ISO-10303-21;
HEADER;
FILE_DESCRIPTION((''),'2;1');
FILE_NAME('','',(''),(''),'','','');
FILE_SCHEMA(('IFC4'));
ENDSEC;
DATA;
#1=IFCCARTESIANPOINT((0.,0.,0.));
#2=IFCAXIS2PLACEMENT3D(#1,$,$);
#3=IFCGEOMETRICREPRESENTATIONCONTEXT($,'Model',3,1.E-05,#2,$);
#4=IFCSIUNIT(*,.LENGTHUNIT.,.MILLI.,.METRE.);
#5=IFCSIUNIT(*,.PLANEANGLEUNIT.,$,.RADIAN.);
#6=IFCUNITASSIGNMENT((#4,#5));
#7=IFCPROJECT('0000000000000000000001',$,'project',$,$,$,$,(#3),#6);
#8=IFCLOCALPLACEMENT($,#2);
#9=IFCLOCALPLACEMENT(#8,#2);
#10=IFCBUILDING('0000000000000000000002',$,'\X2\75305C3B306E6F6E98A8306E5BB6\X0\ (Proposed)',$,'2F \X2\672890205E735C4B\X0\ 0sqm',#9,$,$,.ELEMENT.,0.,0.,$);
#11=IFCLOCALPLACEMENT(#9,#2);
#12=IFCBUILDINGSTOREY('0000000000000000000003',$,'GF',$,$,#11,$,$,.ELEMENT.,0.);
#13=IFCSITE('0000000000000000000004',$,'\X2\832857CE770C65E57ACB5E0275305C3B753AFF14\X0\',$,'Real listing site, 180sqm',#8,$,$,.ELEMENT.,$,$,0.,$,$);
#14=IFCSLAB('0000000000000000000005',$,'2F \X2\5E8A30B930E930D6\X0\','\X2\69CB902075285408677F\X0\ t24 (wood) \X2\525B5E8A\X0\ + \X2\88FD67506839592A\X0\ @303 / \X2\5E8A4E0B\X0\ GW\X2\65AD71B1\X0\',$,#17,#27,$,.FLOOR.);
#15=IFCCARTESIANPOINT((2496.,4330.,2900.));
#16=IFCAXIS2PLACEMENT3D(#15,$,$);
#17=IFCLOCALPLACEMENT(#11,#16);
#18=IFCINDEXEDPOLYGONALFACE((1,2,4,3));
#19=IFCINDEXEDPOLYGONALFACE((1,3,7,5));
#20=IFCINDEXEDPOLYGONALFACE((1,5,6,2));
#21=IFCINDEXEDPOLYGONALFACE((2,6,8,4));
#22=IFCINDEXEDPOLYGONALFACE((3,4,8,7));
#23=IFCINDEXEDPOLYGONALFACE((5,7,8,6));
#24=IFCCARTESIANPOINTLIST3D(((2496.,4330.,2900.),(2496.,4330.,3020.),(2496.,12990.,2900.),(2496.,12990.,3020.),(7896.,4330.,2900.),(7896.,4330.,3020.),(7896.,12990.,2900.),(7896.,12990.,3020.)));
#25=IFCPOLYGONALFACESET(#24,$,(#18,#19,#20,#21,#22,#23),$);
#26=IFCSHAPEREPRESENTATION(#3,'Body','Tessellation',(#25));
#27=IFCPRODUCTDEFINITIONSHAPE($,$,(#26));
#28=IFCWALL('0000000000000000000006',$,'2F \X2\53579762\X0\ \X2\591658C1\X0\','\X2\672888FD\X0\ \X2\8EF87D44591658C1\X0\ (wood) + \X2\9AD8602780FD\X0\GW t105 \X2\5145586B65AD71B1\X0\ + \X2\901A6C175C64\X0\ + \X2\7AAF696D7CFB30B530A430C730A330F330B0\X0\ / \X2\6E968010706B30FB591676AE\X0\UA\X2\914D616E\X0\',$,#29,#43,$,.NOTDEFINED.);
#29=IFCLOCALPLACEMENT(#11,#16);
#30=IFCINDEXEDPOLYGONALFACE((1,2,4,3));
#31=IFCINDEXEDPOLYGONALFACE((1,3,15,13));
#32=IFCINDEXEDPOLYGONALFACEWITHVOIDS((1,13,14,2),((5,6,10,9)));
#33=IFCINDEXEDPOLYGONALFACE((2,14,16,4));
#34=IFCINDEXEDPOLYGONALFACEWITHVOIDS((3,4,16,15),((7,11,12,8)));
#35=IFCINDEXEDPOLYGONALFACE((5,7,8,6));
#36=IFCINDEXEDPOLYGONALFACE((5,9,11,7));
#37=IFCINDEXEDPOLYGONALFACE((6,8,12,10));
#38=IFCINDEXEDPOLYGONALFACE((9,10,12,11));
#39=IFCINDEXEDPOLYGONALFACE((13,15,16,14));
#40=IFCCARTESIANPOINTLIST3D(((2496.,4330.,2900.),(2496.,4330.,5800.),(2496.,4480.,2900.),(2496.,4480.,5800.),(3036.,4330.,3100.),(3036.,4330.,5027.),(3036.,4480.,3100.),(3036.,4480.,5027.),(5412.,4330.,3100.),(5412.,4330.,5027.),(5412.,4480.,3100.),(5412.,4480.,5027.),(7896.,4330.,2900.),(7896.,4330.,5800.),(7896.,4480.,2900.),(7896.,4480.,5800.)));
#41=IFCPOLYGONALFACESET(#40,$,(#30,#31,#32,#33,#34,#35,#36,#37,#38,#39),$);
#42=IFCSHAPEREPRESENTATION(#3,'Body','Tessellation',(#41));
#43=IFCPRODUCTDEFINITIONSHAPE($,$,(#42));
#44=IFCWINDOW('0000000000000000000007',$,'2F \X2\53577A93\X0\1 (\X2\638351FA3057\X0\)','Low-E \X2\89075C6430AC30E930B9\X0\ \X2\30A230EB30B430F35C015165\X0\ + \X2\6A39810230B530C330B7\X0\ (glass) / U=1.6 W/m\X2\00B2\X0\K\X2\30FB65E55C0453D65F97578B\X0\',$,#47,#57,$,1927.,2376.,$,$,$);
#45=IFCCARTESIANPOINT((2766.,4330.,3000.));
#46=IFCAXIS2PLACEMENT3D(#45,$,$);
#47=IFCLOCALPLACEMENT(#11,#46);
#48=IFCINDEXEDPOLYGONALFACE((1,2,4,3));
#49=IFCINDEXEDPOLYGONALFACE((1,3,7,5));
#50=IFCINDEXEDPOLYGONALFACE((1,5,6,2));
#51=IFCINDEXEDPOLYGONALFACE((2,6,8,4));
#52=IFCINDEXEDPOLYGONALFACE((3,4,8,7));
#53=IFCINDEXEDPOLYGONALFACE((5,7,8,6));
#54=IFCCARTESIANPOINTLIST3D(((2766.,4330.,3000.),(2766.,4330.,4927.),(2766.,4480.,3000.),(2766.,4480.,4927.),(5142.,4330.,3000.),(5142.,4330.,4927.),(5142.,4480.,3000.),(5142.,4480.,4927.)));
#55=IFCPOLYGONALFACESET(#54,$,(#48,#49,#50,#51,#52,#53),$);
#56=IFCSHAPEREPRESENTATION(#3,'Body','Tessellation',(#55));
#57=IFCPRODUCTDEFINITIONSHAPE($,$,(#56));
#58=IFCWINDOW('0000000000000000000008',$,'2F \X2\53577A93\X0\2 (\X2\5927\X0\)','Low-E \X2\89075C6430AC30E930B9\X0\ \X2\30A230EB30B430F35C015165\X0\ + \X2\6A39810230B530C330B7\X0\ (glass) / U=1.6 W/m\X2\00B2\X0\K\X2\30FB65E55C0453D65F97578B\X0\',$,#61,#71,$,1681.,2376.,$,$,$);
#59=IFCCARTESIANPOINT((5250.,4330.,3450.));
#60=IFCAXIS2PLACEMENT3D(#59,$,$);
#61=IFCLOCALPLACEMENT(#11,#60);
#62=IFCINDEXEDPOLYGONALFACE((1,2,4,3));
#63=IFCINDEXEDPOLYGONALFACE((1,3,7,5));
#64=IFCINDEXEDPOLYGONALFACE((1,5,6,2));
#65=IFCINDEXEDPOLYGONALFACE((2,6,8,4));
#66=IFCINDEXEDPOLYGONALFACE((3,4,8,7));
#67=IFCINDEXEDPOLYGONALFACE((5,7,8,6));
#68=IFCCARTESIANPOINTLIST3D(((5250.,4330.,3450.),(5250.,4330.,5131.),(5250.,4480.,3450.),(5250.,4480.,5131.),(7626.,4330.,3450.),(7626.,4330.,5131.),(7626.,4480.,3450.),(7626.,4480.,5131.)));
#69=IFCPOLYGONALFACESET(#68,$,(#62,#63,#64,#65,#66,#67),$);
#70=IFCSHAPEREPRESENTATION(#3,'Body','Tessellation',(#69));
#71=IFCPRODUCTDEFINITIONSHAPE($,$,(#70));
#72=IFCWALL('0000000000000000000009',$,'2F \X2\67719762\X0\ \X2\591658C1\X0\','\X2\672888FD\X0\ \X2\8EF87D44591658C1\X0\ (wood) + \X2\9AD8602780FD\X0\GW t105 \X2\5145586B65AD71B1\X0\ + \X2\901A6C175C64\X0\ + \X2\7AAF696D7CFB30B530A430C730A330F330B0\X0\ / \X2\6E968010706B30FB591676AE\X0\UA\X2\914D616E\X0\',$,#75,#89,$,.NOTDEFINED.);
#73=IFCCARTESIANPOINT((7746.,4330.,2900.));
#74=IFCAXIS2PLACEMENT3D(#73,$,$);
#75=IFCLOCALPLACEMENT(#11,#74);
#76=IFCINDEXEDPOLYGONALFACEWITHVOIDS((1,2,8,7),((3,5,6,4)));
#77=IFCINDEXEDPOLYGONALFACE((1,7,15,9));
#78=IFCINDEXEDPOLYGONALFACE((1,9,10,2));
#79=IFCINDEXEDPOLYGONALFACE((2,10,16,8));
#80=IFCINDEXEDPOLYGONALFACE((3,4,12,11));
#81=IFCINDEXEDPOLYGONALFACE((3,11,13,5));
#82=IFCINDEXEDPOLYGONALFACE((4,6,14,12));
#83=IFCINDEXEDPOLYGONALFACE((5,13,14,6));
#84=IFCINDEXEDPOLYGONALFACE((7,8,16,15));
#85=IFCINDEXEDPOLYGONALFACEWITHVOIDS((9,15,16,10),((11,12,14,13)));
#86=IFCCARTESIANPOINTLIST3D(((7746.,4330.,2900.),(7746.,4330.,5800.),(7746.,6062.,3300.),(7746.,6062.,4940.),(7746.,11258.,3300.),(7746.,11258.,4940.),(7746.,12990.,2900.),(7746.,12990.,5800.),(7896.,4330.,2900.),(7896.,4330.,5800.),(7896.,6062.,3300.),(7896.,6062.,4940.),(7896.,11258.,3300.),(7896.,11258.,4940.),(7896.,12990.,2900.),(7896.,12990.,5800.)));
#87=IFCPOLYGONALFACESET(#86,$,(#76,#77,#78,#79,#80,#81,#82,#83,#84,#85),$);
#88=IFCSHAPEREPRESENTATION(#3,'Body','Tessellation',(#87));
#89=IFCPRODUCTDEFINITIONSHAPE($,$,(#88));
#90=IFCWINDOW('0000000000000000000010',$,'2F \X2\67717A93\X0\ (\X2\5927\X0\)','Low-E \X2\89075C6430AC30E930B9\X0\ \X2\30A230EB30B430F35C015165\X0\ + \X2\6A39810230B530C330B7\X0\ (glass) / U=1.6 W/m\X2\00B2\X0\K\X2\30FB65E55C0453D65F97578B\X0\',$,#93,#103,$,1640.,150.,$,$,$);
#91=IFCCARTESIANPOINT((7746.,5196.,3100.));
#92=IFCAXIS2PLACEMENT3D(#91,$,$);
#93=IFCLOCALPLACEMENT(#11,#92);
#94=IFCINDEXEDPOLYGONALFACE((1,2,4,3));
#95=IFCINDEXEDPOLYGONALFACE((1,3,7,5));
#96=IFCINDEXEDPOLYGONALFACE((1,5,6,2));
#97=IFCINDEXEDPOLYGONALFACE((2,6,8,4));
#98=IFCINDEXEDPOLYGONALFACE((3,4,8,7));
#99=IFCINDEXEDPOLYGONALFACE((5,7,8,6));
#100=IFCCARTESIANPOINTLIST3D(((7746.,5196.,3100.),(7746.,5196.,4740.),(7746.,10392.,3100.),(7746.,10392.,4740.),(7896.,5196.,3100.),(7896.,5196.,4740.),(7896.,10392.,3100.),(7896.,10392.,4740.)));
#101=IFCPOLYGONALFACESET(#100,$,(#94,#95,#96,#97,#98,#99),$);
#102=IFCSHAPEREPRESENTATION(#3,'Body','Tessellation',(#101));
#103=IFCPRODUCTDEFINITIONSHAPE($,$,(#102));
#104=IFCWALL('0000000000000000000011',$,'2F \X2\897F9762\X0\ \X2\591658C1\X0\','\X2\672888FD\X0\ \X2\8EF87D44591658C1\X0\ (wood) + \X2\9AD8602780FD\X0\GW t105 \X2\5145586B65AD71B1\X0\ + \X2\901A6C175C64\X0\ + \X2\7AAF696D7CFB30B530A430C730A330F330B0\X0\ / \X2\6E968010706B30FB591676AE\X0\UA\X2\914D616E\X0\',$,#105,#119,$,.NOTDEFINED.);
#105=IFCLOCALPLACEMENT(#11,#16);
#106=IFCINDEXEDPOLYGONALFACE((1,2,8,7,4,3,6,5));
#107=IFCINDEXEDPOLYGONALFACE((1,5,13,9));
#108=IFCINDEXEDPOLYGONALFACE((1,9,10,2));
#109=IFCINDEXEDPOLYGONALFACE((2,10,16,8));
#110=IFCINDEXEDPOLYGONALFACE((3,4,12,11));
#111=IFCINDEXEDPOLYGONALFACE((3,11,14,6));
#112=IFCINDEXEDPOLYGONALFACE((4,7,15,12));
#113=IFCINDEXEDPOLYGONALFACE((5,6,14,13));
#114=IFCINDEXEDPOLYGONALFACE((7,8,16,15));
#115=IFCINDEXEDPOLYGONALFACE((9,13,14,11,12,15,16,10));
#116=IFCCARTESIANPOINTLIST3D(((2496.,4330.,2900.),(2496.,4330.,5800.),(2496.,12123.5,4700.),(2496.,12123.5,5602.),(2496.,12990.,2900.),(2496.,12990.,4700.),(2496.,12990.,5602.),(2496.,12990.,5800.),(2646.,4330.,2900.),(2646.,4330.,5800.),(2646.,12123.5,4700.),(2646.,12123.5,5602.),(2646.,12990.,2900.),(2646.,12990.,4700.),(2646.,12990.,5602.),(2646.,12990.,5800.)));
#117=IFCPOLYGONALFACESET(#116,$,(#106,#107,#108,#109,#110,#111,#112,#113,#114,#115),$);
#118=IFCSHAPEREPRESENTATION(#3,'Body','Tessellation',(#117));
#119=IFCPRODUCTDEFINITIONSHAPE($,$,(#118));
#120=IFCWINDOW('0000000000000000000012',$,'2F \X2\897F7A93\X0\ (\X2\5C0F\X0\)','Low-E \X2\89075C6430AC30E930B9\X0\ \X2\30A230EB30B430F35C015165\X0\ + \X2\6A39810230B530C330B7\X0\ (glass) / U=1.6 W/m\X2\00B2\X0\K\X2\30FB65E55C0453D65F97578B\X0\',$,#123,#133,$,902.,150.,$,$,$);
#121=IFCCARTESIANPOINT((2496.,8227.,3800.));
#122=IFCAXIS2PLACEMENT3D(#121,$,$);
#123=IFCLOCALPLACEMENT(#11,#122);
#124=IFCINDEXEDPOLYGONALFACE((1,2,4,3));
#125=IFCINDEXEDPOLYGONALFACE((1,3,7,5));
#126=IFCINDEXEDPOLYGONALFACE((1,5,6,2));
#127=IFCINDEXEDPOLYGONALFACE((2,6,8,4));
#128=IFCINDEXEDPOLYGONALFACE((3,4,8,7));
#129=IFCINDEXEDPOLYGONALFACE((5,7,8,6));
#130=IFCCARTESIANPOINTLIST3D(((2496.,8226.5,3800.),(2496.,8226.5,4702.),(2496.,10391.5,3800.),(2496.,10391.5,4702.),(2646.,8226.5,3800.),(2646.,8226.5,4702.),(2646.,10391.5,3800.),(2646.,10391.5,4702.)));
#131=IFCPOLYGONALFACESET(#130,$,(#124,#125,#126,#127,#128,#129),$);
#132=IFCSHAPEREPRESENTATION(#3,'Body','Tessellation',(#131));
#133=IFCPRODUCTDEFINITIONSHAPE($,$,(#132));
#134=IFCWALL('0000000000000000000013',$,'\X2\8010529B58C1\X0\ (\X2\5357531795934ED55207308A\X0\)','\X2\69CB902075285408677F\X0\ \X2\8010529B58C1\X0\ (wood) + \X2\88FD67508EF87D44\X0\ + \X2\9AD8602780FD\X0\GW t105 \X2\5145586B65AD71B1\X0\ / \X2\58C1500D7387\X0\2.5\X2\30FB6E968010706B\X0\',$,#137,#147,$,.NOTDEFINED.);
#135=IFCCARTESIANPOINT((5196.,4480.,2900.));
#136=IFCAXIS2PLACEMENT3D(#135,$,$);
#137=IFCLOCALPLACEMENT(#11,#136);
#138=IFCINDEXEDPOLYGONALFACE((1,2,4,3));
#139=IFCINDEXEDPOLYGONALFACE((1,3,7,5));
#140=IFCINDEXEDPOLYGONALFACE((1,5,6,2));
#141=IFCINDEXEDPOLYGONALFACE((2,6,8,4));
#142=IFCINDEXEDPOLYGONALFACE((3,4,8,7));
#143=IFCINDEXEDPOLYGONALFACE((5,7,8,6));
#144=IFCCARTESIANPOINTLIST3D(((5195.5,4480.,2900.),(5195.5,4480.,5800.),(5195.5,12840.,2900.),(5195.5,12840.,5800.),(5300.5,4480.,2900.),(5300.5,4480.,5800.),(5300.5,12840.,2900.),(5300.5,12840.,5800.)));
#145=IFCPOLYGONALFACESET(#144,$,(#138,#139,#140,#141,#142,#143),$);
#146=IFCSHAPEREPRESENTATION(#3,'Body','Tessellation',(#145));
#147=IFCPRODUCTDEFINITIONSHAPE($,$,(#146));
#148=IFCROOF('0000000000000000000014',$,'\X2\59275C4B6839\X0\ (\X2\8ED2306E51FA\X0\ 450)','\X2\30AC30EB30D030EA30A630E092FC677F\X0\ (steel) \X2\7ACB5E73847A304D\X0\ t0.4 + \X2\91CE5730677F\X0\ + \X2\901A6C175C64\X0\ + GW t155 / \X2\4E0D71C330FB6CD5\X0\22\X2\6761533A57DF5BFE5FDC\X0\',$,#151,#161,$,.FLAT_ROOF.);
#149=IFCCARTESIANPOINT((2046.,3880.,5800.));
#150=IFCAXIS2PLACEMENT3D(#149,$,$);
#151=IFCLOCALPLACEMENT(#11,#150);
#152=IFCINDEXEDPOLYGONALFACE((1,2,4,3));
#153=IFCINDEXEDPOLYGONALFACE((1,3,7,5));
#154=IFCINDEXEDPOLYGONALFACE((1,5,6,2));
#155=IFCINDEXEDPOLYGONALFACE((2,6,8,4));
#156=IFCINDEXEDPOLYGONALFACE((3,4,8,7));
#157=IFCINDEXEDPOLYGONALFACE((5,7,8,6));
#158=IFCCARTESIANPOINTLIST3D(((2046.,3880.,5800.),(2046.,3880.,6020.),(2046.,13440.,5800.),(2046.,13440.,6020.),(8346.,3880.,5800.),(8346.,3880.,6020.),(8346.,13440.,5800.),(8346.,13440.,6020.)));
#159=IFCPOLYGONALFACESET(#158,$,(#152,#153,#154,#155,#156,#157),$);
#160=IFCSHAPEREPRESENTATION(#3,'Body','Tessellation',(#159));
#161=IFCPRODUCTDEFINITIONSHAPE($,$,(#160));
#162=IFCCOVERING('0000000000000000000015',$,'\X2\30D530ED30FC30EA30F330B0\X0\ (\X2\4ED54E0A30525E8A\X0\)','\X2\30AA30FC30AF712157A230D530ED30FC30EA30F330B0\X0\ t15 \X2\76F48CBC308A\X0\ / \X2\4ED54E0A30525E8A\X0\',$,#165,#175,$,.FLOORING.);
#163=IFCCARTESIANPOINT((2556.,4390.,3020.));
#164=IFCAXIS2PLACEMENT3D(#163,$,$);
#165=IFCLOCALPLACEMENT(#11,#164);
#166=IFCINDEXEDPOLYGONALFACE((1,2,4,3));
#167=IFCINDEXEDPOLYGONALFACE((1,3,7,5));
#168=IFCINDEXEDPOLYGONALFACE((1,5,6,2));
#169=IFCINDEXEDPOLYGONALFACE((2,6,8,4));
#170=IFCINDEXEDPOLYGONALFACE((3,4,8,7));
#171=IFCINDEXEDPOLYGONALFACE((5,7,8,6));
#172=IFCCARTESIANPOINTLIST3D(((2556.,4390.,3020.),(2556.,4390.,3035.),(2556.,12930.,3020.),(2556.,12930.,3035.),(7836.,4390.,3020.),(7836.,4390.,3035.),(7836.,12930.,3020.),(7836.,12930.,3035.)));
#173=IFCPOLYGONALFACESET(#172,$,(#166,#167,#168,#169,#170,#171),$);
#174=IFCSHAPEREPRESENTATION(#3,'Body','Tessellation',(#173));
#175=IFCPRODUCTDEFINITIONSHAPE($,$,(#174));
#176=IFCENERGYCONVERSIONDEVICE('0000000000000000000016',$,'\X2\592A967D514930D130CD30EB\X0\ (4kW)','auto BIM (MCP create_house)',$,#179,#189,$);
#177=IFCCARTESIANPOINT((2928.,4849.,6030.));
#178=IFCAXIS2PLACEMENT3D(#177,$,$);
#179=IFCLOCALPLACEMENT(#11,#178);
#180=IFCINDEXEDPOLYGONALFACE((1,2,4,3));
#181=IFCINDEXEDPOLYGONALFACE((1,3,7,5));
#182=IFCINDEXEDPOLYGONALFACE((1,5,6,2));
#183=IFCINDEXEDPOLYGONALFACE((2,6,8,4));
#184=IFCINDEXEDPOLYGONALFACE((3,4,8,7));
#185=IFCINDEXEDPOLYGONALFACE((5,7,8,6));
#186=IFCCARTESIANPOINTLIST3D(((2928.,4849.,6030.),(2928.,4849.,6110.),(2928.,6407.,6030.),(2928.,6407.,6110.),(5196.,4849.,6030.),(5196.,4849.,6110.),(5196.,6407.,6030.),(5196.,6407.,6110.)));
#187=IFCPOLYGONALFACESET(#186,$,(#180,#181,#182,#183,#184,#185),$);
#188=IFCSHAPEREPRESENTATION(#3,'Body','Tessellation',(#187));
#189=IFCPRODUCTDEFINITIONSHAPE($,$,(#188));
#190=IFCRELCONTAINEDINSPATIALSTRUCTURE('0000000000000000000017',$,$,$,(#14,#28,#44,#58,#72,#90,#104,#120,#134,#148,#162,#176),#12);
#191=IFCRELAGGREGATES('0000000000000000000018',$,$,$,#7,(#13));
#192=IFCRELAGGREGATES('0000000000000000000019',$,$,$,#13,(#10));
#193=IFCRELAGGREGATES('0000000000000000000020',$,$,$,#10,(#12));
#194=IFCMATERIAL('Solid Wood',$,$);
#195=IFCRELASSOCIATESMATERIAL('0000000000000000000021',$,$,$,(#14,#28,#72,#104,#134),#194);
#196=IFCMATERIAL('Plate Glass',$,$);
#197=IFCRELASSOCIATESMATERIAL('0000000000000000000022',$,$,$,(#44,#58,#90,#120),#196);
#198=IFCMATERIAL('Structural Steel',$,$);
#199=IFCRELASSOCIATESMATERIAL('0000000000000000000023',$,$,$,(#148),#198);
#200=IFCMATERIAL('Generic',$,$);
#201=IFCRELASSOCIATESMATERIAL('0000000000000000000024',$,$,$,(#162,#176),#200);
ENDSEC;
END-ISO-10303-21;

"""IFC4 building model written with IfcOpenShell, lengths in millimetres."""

from ifc_helpers import new_model, si_unit, frame, frame_2d, origin, place, context, project, spatial, rectangle, extrude, material, element, fill, save


model = new_model("IFC4")

# Units and contexts
model_context = context("Model", 3, precision=1e-05, world=origin())
ifc_project = project(units=[si_unit("LENGTHUNIT", "METRE", prefix="MILLI"), si_unit("PLANEANGLEUNIT", "RADIAN")], contexts=[model_context])

# Site, building, storey
site_placement = place(None, origin())
site = spatial("IfcSite", under=ifc_project, at=site_placement, Name="茨城県日立市田尻町４", ObjectType="Real listing site, 180sqm", CompositionType="ELEMENT", RefElevation=0.0)
building_placement = place(site_placement, origin())
building = spatial("IfcBuilding", under=site, at=building_placement, Name="田尻の潮風の家 (Proposed)", ObjectType="2F 木造平屋 0sqm", CompositionType="ELEMENT", ElevationOfRefHeight=0.0, ElevationOfTerrain=0.0)
storey_placement = place(building_placement, origin())
storey = spatial("IfcBuildingStorey", under=building, at=storey_placement, Name="GF", CompositionType="ELEMENT", Elevation=0.0)

# Slab
ifc_material_1 = material(Name="Solid Wood")
slab_placement = place(storey_placement, frame((2496.0, 4330.0, 2900.0)))
element("IfcSlab", 1, at=slab_placement, inside=storey, material=ifc_material_1, Name="2F 床スラブ", Description="構造用合板 t24 (wood) 剛床 + 製材根太 @303 / 床下 GW断熱", PredefinedType="FLOOR", context=model_context, shape_type="SweptSolid", body=[
    extrude(rectangle(XDim=5400.0, YDim=8660.0, at=frame_2d((2700.0, 4330.0))), frame((2496.0, 4330.0, 2900.0)), (0.0, 0.0, 1.0), 120.0),
])

# Wall, openings, windows
wall_1_placement = place(storey_placement, frame((2496.0, 4330.0, 2900.0)))
wall_1 = element("IfcWall", 2, at=wall_1_placement, inside=storey, material=ifc_material_1, Name="2F 南面 外壁", Description="木製 軸組外壁 (wood) + 高性能GW t105 充填断熱 + 通気層 + 窯業系サイディング / 準耐火・外皮UA配慮", PredefinedType="NOTDEFINED", context=model_context, shape_type="SweptSolid", body=[
    extrude(rectangle(XDim=5400.0, YDim=150.0, at=frame_2d((2700.0, 75.0))), frame((2496.0, 4330.0, 2900.0)), (0.0, 0.0, 1.0), 2900.0),
])
opening_1_placement = place(storey_placement, frame((2766.0, 4330.0, 3000.0)))
opening_1 = element("IfcOpeningElement", 3, at=opening_1_placement, cuts=wall_1, PredefinedType="NOTDEFINED", context=model_context, shape_type="SweptSolid", body=[
    extrude(rectangle(XDim=2376.0, YDim=150.0, at=frame_2d((1188.0, 75.0))), frame((2766.0, 4330.0, 3000.0)), (0.0, 0.0, 1.0), 1927.0),
])
opening_2_placement = place(storey_placement, frame((5250.0, 4330.0, 3450.0)))
opening_2 = element("IfcOpeningElement", 4, at=opening_2_placement, cuts=wall_1, PredefinedType="NOTDEFINED", context=model_context, shape_type="SweptSolid", body=[
    extrude(rectangle(XDim=2376.0, YDim=150.0, at=frame_2d((1188.0, 75.0))), frame((5250.0, 4330.0, 3450.0)), (0.0, 0.0, 1.0), 1681.0),
])
ifc_material_2 = material(Name="Plate Glass")
window_1_placement = place(storey_placement, frame((2766.0, 4330.0, 3000.0)))
window_1 = element("IfcWindow", 5, at=window_1_placement, inside=storey, material=ifc_material_2, Name="2F 南窓1 (掃出し)", Description="Low-E 複層ガラス アルゴン封入 + 樹脂サッシ (glass) / U=1.6 W/m²K・日射取得型", OverallHeight=1927.0, OverallWidth=2376.0, context=model_context, shape_type="SweptSolid", body=[
    extrude(rectangle(XDim=2376.0, YDim=150.0, at=frame_2d((1188.0, 75.0))), frame((2766.0, 4330.0, 3000.0)), (0.0, 0.0, 1.0), 1927.0),
])
fill(opening_1, window_1)
window_2_placement = place(storey_placement, frame((5250.0, 4330.0, 3450.0)))
window_2 = element("IfcWindow", 6, at=window_2_placement, inside=storey, material=ifc_material_2, Name="2F 南窓2 (大)", Description="Low-E 複層ガラス アルゴン封入 + 樹脂サッシ (glass) / U=1.6 W/m²K・日射取得型", OverallHeight=1681.0, OverallWidth=2376.0, context=model_context, shape_type="SweptSolid", body=[
    extrude(rectangle(XDim=2376.0, YDim=150.0, at=frame_2d((1188.0, 75.0))), frame((5250.0, 4330.0, 3450.0)), (0.0, 0.0, 1.0), 1681.0),
])
fill(opening_2, window_2)

# Walls, openings, windows
wall_2_placement = place(storey_placement, frame((7746.0, 4330.0, 2900.0)))
wall_2 = element("IfcWall", 7, at=wall_2_placement, inside=storey, material=ifc_material_1, Name="2F 東面 外壁", Description="木製 軸組外壁 (wood) + 高性能GW t105 充填断熱 + 通気層 + 窯業系サイディング / 準耐火・外皮UA配慮", PredefinedType="NOTDEFINED", context=model_context, shape_type="SweptSolid", body=[
    extrude(rectangle(XDim=150.0, YDim=8660.0, at=frame_2d((75.0, 4330.0))), frame((7746.0, 4330.0, 2900.0)), (0.0, 0.0, 1.0), 2900.0),
])
opening_3_placement = place(storey_placement, frame((7746.0, 5196.0, 3100.0)))
opening_3 = element("IfcOpeningElement", 8, at=opening_3_placement, cuts=wall_2, PredefinedType="NOTDEFINED", context=model_context, shape_type="SweptSolid", body=[
    extrude(rectangle(XDim=150.0, YDim=5196.0, at=frame_2d((75.0, 2598.0))), frame((7746.0, 5196.0, 3100.0)), (0.0, 0.0, 1.0), 1640.0),
])
window_3_placement = place(storey_placement, frame((7746.0, 5196.0, 3100.0)))
window_3 = element("IfcWindow", 9, at=window_3_placement, inside=storey, material=ifc_material_2, Name="2F 東窓 (大)", Description="Low-E 複層ガラス アルゴン封入 + 樹脂サッシ (glass) / U=1.6 W/m²K・日射取得型", OverallHeight=1640.0, OverallWidth=150.0, context=model_context, shape_type="SweptSolid", body=[
    extrude(rectangle(XDim=150.0, YDim=5196.0, at=frame_2d((75.0, 2598.0))), frame((7746.0, 5196.0, 3100.0)), (0.0, 0.0, 1.0), 1640.0),
])
fill(opening_3, window_3)
wall_3_placement = place(storey_placement, frame((2496.0, 4330.0, 2900.0)))
wall_3 = element("IfcWall", 10, at=wall_3_placement, inside=storey, material=ifc_material_1, Name="2F 西面 外壁", Description="木製 軸組外壁 (wood) + 高性能GW t105 充填断熱 + 通気層 + 窯業系サイディング / 準耐火・外皮UA配慮", PredefinedType="NOTDEFINED", context=model_context, shape_type="SweptSolid", body=[
    extrude(rectangle(XDim=150.0, YDim=8660.0, at=frame_2d((75.0, 4330.0))), frame((2496.0, 4330.0, 2900.0)), (0.0, 0.0, 1.0), 2900.0),
])
opening_4_placement = place(storey_placement, frame((2496.0, 8227.0, 3800.0)))
opening_4 = element("IfcOpeningElement", 11, at=opening_4_placement, cuts=wall_3, PredefinedType="NOTDEFINED", context=model_context, shape_type="SweptSolid", body=[
    extrude(rectangle(XDim=150.0, YDim=2165.0, at=frame_2d((75.0, 1082.0))), frame((2496.0, 8227.0, 3800.0)), (0.0, 0.0, 1.0), 902.0),
])
window_4_placement = place(storey_placement, frame((2496.0, 8227.0, 3800.0)))
window_4 = element("IfcWindow", 12, at=window_4_placement, inside=storey, material=ifc_material_2, Name="2F 西窓 (小)", Description="Low-E 複層ガラス アルゴン封入 + 樹脂サッシ (glass) / U=1.6 W/m²K・日射取得型", OverallHeight=902.0, OverallWidth=150.0, context=model_context, shape_type="SweptSolid", body=[
    extrude(rectangle(XDim=150.0, YDim=2165.0, at=frame_2d((75.0, 1082.0))), frame((2496.0, 8227.0, 3800.0)), (0.0, 0.0, 1.0), 902.0),
])
fill(opening_4, window_4)

# Wall
wall_4_placement = place(storey_placement, frame((5196.0, 4480.0, 2900.0)))
element("IfcWall", 13, at=wall_4_placement, inside=storey, material=ifc_material_1, Name="耐力壁 (南北間仕切り)", Description="構造用合板 耐力壁 (wood) + 製材軸組 + 高性能GW t105 充填断熱 / 壁倍率2.5・準耐火", PredefinedType="NOTDEFINED", context=model_context, shape_type="SweptSolid", body=[
    extrude(rectangle(XDim=105.0, YDim=8360.0, at=frame_2d((52.0, 4180.0))), frame((5196.0, 4480.0, 2900.0)), (0.0, 0.0, 1.0), 2900.0),
])

# Roof
ifc_material_3 = material(Name="Structural Steel")
roof_placement = place(storey_placement, frame((2046.0, 3880.0, 5800.0)))
element("IfcRoof", 14, at=roof_placement, inside=storey, material=ifc_material_3, Name="大屋根 (軒の出 450)", Description="ガルバリウム鋼板 (steel) 立平葺き t0.4 + 野地板 + 通気層 + GW t155 / 不燃・法22条区域対応", PredefinedType="FLAT_ROOF", context=model_context, shape_type="SweptSolid", body=[
    extrude(rectangle(XDim=6300.0, YDim=9560.0, at=frame_2d((3150.0, 4780.0))), frame((2046.0, 3880.0, 5800.0)), (0.0, 0.0, 1.0), 220.0),
])

# Covering
ifc_material_4 = material(Name="Generic")
covering_placement = place(storey_placement, frame((2556.0, 4390.0, 3020.0)))
element("IfcCovering", 15, at=covering_placement, inside=storey, material=ifc_material_4, Name="フローリング (仕上げ床)", Description="オーク無垢フローリング t15 直貼り / 仕上げ床", PredefinedType="FLOORING", context=model_context, shape_type="SweptSolid", body=[
    extrude(rectangle(XDim=5280.0, YDim=8540.0, at=frame_2d((2640.0, 4270.0))), frame((2556.0, 4390.0, 3020.0)), (0.0, 0.0, 1.0), 15.0),
])

# Energy conversion device
energy_conversion_device_placement = place(storey_placement, frame((2928.0, 4849.0, 6030.0)))
element("IfcEnergyConversionDevice", 16, at=energy_conversion_device_placement, inside=storey, material=ifc_material_4, Name="太陽光パネル (4kW)", Description="auto BIM (MCP create_house)", context=model_context, shape_type="SweptSolid", body=[
    extrude(rectangle(XDim=2268.0, YDim=1558.0, at=frame_2d((1134.0, 779.0))), frame((2928.0, 4849.0, 6030.0)), (0.0, 0.0, 1.0), 80.0),
])

save(model, "model.ifc")
